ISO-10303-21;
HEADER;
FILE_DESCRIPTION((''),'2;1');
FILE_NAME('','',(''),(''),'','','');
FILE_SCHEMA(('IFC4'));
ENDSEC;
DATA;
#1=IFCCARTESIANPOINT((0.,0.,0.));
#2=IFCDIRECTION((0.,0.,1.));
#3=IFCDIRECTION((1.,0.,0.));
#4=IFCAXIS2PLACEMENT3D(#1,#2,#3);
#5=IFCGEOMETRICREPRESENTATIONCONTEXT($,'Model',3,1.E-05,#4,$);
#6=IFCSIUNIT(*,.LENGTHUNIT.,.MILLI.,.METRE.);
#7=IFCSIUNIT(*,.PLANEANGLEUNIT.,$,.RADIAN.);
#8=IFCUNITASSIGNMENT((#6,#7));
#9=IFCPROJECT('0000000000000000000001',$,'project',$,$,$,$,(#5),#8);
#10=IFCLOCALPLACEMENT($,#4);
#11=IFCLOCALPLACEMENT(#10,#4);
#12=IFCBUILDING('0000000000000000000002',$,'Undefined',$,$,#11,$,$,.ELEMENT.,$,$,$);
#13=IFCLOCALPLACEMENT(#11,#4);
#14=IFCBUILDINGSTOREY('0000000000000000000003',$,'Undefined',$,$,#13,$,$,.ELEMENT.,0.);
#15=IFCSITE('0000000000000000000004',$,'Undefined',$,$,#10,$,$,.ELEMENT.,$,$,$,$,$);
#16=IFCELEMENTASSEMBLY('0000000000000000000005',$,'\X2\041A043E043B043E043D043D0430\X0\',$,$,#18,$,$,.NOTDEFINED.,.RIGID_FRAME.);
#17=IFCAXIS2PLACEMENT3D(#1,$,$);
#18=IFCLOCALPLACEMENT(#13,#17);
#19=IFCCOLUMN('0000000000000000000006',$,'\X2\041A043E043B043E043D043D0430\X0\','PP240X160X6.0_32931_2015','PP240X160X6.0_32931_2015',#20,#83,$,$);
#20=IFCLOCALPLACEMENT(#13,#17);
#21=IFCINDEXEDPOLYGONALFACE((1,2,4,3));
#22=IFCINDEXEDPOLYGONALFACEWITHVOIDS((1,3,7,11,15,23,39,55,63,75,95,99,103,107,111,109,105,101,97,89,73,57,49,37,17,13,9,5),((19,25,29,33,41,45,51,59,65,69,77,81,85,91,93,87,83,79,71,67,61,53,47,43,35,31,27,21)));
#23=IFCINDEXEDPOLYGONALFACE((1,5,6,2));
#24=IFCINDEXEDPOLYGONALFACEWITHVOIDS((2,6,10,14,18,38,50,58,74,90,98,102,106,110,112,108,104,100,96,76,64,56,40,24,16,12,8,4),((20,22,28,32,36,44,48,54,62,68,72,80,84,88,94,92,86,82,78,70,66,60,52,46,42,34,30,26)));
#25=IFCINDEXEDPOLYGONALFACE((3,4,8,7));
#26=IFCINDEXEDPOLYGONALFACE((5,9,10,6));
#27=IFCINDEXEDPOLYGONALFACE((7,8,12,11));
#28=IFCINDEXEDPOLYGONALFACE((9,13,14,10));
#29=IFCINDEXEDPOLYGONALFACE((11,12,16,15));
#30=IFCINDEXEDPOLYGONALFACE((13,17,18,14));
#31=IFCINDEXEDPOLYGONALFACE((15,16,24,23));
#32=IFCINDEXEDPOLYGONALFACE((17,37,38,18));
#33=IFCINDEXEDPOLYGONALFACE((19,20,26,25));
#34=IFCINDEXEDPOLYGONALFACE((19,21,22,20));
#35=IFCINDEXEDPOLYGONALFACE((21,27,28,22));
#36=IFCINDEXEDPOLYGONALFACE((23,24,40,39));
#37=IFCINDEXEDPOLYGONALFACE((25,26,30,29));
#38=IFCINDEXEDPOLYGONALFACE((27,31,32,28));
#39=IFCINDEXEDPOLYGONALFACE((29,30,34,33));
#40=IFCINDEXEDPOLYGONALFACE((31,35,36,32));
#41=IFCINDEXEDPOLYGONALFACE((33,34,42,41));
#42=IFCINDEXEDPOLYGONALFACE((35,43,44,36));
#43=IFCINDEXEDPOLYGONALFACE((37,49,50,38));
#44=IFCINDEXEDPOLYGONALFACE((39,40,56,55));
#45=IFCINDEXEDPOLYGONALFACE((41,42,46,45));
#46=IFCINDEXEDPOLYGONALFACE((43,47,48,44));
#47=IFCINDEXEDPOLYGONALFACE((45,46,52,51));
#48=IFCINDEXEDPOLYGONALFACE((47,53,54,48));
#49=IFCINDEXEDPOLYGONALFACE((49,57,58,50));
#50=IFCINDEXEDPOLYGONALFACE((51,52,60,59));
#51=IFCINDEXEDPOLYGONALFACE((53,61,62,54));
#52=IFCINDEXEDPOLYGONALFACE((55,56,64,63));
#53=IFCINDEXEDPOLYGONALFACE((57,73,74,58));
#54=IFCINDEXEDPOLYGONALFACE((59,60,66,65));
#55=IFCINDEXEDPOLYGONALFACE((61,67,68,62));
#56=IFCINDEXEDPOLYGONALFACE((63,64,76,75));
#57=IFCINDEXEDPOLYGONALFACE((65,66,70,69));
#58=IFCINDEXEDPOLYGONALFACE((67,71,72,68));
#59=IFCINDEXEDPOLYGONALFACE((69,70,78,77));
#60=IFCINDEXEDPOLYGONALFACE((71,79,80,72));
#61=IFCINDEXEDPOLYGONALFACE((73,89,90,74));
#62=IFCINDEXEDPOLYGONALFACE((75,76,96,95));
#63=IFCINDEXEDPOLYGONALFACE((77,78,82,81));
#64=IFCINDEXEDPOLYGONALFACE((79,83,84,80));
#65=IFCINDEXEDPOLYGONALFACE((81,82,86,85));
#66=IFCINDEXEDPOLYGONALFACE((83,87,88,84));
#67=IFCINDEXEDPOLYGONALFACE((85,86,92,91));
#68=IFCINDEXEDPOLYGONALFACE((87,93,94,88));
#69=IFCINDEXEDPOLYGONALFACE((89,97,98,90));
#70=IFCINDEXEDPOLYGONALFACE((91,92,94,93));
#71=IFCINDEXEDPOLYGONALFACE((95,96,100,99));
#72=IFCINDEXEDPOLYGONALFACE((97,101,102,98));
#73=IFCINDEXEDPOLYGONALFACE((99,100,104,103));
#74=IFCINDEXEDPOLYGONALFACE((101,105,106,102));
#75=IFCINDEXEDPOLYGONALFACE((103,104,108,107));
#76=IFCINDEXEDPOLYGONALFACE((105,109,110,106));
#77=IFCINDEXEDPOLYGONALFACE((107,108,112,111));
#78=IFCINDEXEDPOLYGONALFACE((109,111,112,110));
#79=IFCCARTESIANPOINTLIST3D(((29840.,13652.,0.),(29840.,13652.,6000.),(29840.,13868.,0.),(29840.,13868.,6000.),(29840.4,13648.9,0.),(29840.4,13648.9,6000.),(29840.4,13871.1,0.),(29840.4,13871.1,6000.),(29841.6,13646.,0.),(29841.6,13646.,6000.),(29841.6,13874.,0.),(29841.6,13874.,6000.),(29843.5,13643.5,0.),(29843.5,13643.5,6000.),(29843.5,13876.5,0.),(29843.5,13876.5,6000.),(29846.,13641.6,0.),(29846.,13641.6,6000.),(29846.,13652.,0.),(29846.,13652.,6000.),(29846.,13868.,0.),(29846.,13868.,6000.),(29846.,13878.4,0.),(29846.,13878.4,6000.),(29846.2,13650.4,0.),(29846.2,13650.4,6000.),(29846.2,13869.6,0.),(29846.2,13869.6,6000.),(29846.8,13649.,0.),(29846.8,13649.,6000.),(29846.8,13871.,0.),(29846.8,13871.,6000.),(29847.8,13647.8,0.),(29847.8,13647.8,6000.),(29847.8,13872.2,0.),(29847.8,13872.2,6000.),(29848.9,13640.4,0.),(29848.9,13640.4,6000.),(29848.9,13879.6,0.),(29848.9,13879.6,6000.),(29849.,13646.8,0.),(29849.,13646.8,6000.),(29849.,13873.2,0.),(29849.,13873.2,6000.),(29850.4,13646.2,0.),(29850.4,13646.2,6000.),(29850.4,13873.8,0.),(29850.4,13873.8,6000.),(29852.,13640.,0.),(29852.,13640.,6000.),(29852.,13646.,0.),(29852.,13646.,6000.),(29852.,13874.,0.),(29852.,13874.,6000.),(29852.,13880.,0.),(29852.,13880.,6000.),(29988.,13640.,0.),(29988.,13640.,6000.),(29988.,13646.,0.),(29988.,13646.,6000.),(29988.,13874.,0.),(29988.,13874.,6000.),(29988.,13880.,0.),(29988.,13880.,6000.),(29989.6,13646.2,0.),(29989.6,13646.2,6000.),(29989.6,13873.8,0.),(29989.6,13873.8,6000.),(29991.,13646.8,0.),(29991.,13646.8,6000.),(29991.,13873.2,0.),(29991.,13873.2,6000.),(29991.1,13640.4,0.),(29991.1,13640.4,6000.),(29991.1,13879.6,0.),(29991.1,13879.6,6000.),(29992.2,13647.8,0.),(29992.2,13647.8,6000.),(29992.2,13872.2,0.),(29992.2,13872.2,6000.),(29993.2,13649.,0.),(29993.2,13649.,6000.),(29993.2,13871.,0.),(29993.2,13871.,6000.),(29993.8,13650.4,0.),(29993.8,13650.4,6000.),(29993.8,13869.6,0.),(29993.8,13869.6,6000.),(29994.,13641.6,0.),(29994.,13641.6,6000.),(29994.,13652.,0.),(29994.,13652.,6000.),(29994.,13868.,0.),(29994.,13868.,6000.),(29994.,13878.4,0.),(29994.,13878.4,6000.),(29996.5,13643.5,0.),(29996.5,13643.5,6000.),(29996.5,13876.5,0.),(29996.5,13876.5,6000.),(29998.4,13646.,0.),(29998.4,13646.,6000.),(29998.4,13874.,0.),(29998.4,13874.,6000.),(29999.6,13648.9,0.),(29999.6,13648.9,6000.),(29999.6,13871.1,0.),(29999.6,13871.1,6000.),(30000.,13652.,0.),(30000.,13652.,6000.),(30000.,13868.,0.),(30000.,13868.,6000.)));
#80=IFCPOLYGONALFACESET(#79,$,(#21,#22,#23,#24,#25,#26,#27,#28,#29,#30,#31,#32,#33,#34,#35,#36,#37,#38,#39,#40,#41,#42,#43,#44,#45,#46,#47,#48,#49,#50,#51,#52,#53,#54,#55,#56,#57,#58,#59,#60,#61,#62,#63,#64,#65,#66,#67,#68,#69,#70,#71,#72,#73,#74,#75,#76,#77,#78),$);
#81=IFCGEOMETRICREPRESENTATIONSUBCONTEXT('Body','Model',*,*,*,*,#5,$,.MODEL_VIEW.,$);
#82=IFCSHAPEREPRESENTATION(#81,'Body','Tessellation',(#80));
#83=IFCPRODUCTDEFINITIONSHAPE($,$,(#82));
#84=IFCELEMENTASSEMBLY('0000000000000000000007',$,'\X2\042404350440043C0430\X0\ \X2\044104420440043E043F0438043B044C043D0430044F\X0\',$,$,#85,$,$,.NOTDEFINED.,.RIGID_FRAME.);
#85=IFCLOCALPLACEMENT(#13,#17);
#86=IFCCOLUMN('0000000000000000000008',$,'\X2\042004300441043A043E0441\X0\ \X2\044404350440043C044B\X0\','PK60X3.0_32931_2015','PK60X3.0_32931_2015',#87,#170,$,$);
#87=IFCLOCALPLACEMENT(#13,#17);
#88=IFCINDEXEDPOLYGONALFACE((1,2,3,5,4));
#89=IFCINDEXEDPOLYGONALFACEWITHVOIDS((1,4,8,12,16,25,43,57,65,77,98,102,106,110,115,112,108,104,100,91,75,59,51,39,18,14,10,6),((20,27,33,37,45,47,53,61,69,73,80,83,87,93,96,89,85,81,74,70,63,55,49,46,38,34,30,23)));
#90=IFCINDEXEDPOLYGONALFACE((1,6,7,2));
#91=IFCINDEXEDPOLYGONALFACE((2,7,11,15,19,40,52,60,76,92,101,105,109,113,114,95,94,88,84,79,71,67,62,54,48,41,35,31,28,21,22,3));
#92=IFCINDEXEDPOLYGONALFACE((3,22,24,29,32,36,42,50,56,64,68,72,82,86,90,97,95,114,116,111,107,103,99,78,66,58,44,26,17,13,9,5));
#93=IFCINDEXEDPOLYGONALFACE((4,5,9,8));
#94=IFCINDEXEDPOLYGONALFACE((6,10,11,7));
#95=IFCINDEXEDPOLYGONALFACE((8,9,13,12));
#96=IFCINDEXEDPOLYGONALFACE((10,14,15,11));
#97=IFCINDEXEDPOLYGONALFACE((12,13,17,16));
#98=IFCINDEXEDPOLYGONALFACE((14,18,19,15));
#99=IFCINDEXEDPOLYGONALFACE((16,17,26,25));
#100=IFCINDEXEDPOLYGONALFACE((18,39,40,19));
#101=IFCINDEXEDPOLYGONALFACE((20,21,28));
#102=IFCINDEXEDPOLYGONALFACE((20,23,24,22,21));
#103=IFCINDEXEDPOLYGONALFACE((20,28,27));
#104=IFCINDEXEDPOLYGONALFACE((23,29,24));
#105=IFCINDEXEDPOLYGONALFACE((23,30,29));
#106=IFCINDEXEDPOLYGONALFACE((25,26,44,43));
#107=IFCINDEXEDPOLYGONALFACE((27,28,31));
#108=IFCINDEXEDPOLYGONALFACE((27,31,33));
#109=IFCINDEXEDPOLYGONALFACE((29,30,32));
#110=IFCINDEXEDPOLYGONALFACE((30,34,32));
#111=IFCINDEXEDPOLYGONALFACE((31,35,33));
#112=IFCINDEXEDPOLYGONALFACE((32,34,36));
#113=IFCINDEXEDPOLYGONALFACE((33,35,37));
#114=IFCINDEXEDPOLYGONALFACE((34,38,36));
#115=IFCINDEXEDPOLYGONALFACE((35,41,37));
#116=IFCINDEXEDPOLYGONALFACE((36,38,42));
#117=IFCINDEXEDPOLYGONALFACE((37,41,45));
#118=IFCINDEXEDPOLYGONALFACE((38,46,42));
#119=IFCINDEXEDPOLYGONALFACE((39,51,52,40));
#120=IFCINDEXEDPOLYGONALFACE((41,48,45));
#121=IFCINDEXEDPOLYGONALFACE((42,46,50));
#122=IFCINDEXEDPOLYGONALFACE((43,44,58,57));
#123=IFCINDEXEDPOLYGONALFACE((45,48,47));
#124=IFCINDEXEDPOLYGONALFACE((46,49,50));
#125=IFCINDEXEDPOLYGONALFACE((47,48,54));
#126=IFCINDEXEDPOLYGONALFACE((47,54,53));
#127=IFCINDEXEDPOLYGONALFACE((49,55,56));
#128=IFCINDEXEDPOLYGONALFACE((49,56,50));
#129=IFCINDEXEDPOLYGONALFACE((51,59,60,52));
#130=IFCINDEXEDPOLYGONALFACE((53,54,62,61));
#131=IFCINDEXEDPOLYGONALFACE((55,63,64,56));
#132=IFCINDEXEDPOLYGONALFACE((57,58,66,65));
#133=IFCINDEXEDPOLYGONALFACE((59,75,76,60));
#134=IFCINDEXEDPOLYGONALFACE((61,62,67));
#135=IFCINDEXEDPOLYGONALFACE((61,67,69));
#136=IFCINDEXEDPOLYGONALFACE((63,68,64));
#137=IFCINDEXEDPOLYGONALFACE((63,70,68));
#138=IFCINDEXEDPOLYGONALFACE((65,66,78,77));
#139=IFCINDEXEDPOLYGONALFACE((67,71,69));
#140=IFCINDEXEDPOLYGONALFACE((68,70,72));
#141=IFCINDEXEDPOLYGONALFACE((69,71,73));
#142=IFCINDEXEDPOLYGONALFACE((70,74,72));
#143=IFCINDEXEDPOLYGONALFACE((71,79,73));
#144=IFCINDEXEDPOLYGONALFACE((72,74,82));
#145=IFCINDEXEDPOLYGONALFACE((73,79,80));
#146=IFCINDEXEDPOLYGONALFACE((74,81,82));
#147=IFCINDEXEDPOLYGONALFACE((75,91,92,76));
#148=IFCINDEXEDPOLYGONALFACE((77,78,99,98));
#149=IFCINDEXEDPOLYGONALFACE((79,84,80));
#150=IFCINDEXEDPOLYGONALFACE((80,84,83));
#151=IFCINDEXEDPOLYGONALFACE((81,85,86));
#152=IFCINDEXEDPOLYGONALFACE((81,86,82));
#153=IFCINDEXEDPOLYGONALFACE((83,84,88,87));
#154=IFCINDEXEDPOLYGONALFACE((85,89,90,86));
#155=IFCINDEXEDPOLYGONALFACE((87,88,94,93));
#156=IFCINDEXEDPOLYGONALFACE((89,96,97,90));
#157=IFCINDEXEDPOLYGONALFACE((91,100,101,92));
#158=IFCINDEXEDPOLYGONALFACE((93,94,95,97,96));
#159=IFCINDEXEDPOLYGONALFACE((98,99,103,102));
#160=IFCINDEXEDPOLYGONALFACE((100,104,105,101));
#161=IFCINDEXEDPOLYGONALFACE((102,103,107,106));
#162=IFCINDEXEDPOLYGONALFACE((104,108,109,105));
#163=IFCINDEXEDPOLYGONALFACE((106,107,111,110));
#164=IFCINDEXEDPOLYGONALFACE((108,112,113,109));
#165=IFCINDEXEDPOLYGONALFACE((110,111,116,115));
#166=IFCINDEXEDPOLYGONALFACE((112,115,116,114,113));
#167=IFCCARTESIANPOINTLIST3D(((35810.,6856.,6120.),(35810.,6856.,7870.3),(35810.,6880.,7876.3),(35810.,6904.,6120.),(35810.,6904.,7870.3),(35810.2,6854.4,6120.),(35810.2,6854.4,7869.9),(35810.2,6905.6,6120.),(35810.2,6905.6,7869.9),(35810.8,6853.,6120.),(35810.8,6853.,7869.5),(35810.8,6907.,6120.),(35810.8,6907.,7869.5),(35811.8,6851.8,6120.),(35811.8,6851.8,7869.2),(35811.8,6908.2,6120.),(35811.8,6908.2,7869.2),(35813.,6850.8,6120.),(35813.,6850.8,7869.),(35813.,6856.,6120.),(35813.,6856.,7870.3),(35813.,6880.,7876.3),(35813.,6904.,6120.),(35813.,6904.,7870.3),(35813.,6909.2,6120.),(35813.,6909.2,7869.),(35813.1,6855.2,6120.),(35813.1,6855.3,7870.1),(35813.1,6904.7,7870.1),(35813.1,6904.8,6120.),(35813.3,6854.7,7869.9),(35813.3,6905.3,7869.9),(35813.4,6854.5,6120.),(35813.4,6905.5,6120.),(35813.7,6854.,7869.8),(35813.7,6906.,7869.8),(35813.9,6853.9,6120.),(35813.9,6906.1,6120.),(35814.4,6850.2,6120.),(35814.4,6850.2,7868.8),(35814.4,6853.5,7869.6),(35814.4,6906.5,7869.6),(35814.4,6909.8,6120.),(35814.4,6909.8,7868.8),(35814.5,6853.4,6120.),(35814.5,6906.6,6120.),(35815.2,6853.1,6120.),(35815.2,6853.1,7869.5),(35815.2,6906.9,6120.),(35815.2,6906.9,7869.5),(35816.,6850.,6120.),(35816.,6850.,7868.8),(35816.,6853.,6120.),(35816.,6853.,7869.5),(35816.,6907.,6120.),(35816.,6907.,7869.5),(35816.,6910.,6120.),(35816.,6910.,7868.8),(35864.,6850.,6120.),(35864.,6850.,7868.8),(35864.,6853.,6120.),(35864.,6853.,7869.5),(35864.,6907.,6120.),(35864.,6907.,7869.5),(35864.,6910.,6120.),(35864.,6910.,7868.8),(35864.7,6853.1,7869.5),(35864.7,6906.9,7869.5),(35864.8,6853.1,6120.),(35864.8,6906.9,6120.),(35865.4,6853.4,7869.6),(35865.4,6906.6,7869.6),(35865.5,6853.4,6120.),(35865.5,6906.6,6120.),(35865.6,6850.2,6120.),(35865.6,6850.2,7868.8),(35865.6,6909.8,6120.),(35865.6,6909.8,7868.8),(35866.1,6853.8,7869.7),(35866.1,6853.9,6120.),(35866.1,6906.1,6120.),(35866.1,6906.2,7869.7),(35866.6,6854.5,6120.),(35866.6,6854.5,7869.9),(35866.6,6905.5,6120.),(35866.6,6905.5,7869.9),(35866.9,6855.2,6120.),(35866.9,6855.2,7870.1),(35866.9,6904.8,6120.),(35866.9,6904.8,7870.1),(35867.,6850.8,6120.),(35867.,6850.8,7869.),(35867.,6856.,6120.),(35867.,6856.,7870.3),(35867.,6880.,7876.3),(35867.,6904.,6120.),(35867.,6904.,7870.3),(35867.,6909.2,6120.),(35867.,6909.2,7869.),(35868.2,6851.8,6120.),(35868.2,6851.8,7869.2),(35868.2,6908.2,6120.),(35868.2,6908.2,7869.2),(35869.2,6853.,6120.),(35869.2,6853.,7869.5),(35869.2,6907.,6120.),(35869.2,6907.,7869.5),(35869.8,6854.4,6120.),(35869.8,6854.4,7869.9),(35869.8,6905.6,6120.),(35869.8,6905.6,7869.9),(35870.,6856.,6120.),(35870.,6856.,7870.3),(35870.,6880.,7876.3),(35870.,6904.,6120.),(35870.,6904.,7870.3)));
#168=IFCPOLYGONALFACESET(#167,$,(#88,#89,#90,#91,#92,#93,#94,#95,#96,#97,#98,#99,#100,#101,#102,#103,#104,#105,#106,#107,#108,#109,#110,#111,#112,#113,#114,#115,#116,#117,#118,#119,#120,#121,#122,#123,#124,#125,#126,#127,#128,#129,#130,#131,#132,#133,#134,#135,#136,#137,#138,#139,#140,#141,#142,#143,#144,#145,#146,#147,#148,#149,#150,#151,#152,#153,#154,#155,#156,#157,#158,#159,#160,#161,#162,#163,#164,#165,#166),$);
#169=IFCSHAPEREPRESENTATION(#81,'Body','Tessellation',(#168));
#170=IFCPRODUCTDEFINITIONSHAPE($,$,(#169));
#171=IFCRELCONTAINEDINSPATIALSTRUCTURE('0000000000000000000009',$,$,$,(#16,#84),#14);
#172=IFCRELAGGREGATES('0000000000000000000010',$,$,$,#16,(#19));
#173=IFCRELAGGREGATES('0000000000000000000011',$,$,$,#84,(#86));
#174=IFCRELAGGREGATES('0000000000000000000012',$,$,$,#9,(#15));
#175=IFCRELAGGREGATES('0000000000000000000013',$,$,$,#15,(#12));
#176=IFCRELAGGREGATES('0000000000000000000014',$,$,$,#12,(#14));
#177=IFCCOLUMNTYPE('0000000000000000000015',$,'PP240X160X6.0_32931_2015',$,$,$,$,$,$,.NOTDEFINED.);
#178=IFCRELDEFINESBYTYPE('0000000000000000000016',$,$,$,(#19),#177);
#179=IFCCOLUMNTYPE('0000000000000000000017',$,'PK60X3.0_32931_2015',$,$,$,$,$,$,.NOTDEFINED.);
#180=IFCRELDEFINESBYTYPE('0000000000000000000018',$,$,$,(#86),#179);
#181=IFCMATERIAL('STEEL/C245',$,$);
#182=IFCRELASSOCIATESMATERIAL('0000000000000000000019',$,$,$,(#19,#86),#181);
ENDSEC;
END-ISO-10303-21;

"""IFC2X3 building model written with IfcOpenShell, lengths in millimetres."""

from ifc_helpers import new_model, si_unit, frame, origin_with_axes, origin_2d_with_axis, place, context, subcontext, project, spatial, hollow_rectangle, extrude, clip, halfspace, material, type_object, element, aggregate, save


model = new_model("IFC2X3")

# Units and contexts
model_context = context("Model", 3, precision=1e-05, world=origin_with_axes())
body_context = subcontext(model_context, "Body", "Model", "MODEL_VIEW")
ifc_project = project(units=[si_unit("LENGTHUNIT", "METRE", prefix="MILLI"), si_unit("PLANEANGLEUNIT", "RADIAN")], contexts=[model_context])

# Site, building, storey
site_placement = place(None, origin_with_axes())
site = spatial("IfcSite", under=ifc_project, at=site_placement, Name="Undefined", CompositionType="ELEMENT")
building_placement = place(site_placement, origin_with_axes())
building = spatial("IfcBuilding", under=site, at=building_placement, Name="Undefined", CompositionType="ELEMENT")
storey_placement = place(building_placement, origin_with_axes())
storey = spatial("IfcBuildingStorey", under=building, at=storey_placement, Name="Undefined", CompositionType="ELEMENT", Elevation=0.0)

# Element assembly, column
ifc_material = material(Name="STEEL/C245")
column_type_1 = type_object("IfcColumnType", Name="PP240X160X6.0_32931_2015", PredefinedType="NOTDEFINED")
assembly_1_placement = place(storey_placement, origin_with_axes())
assembly_1 = element("IfcElementAssembly", 1, at=assembly_1_placement, inside=storey, Name="Колонна", AssemblyPlace="NOTDEFINED", PredefinedType="RIGID_FRAME")
column_1_placement = place(assembly_1_placement, frame((29920.0, 13760.0, 0.0), z_axis=(0.0, 0.0, 1.0), x_axis=(0.0, 1.0, 0.0)))
column_1 = element("IfcColumn", 2, at=column_1_placement, type_object=column_type_1, material=ifc_material, Name="Колонна", Description="PP240X160X6.0_32931_2015", ObjectType="PP240X160X6.0_32931_2015", context=body_context, shape_type="SweptSolid", body=[
    extrude(hollow_rectangle(XDim=160.0, YDim=240.0, WallThickness=6.0, InnerFilletRadius=6.0, OuterFilletRadius=12.0, at=origin_2d_with_axis()), frame((0.0, 0.0, 6000.0), z_axis=(0.0, 0.0, -1.0), x_axis=(0.0, 1.0, 0.0)), (0.0, 0.0, 1.0), 6000.0),
])
aggregate(assembly_1, [column_1])

# Element assembly, column
assembly_2_placement = place(storey_placement, origin_with_axes())
assembly_2 = element("IfcElementAssembly", 3, at=assembly_2_placement, inside=storey, Name="Ферма стропильная", AssemblyPlace="NOTDEFINED", PredefinedType="RIGID_FRAME")
column_type_2 = type_object("IfcColumnType", Name="PK60X3.0_32931_2015", PredefinedType="NOTDEFINED")
column_2_placement = place(assembly_2_placement, frame((35840.0, 6880.0, 6120.0), z_axis=(0.0, 0.0, 1.0), x_axis=(-1.0, 0.0, 0.0)))
column_2 = element("IfcColumn", 4, at=column_2_placement, type_object=column_type_2, material=ifc_material, Name="Раскос фермы", Description="PK60X3.0_32931_2015", ObjectType="PK60X3.0_32931_2015", context=body_context, shape_type="Clipping", body=[
    clip(clip(extrude(hollow_rectangle(XDim=60.0, YDim=60.0, WallThickness=3.0, InnerFilletRadius=3.0, OuterFilletRadius=6.0, at=origin_2d_with_axis()), frame((0.0, 0.0, 1756.3), z_axis=(0.0, 0.0, -1.0), x_axis=(0.0, 1.0, 0.0)), (0.0, 0.0, 1.0), 1756.3), halfspace(frame((-30.0, 30.0, 1763.8), z_axis=(0.0, -0.243188, 0.969979), x_axis=(1.0, 0.0, 0.0)), False)), halfspace(frame((0.0, 4455.7, 639.2), z_axis=(0.0, -0.243188, -0.969979), x_axis=(-1.0, 0.0, 0.0)), True)),
])

aggregate(assembly_2, [column_2])

save(model, "model.ifc")
